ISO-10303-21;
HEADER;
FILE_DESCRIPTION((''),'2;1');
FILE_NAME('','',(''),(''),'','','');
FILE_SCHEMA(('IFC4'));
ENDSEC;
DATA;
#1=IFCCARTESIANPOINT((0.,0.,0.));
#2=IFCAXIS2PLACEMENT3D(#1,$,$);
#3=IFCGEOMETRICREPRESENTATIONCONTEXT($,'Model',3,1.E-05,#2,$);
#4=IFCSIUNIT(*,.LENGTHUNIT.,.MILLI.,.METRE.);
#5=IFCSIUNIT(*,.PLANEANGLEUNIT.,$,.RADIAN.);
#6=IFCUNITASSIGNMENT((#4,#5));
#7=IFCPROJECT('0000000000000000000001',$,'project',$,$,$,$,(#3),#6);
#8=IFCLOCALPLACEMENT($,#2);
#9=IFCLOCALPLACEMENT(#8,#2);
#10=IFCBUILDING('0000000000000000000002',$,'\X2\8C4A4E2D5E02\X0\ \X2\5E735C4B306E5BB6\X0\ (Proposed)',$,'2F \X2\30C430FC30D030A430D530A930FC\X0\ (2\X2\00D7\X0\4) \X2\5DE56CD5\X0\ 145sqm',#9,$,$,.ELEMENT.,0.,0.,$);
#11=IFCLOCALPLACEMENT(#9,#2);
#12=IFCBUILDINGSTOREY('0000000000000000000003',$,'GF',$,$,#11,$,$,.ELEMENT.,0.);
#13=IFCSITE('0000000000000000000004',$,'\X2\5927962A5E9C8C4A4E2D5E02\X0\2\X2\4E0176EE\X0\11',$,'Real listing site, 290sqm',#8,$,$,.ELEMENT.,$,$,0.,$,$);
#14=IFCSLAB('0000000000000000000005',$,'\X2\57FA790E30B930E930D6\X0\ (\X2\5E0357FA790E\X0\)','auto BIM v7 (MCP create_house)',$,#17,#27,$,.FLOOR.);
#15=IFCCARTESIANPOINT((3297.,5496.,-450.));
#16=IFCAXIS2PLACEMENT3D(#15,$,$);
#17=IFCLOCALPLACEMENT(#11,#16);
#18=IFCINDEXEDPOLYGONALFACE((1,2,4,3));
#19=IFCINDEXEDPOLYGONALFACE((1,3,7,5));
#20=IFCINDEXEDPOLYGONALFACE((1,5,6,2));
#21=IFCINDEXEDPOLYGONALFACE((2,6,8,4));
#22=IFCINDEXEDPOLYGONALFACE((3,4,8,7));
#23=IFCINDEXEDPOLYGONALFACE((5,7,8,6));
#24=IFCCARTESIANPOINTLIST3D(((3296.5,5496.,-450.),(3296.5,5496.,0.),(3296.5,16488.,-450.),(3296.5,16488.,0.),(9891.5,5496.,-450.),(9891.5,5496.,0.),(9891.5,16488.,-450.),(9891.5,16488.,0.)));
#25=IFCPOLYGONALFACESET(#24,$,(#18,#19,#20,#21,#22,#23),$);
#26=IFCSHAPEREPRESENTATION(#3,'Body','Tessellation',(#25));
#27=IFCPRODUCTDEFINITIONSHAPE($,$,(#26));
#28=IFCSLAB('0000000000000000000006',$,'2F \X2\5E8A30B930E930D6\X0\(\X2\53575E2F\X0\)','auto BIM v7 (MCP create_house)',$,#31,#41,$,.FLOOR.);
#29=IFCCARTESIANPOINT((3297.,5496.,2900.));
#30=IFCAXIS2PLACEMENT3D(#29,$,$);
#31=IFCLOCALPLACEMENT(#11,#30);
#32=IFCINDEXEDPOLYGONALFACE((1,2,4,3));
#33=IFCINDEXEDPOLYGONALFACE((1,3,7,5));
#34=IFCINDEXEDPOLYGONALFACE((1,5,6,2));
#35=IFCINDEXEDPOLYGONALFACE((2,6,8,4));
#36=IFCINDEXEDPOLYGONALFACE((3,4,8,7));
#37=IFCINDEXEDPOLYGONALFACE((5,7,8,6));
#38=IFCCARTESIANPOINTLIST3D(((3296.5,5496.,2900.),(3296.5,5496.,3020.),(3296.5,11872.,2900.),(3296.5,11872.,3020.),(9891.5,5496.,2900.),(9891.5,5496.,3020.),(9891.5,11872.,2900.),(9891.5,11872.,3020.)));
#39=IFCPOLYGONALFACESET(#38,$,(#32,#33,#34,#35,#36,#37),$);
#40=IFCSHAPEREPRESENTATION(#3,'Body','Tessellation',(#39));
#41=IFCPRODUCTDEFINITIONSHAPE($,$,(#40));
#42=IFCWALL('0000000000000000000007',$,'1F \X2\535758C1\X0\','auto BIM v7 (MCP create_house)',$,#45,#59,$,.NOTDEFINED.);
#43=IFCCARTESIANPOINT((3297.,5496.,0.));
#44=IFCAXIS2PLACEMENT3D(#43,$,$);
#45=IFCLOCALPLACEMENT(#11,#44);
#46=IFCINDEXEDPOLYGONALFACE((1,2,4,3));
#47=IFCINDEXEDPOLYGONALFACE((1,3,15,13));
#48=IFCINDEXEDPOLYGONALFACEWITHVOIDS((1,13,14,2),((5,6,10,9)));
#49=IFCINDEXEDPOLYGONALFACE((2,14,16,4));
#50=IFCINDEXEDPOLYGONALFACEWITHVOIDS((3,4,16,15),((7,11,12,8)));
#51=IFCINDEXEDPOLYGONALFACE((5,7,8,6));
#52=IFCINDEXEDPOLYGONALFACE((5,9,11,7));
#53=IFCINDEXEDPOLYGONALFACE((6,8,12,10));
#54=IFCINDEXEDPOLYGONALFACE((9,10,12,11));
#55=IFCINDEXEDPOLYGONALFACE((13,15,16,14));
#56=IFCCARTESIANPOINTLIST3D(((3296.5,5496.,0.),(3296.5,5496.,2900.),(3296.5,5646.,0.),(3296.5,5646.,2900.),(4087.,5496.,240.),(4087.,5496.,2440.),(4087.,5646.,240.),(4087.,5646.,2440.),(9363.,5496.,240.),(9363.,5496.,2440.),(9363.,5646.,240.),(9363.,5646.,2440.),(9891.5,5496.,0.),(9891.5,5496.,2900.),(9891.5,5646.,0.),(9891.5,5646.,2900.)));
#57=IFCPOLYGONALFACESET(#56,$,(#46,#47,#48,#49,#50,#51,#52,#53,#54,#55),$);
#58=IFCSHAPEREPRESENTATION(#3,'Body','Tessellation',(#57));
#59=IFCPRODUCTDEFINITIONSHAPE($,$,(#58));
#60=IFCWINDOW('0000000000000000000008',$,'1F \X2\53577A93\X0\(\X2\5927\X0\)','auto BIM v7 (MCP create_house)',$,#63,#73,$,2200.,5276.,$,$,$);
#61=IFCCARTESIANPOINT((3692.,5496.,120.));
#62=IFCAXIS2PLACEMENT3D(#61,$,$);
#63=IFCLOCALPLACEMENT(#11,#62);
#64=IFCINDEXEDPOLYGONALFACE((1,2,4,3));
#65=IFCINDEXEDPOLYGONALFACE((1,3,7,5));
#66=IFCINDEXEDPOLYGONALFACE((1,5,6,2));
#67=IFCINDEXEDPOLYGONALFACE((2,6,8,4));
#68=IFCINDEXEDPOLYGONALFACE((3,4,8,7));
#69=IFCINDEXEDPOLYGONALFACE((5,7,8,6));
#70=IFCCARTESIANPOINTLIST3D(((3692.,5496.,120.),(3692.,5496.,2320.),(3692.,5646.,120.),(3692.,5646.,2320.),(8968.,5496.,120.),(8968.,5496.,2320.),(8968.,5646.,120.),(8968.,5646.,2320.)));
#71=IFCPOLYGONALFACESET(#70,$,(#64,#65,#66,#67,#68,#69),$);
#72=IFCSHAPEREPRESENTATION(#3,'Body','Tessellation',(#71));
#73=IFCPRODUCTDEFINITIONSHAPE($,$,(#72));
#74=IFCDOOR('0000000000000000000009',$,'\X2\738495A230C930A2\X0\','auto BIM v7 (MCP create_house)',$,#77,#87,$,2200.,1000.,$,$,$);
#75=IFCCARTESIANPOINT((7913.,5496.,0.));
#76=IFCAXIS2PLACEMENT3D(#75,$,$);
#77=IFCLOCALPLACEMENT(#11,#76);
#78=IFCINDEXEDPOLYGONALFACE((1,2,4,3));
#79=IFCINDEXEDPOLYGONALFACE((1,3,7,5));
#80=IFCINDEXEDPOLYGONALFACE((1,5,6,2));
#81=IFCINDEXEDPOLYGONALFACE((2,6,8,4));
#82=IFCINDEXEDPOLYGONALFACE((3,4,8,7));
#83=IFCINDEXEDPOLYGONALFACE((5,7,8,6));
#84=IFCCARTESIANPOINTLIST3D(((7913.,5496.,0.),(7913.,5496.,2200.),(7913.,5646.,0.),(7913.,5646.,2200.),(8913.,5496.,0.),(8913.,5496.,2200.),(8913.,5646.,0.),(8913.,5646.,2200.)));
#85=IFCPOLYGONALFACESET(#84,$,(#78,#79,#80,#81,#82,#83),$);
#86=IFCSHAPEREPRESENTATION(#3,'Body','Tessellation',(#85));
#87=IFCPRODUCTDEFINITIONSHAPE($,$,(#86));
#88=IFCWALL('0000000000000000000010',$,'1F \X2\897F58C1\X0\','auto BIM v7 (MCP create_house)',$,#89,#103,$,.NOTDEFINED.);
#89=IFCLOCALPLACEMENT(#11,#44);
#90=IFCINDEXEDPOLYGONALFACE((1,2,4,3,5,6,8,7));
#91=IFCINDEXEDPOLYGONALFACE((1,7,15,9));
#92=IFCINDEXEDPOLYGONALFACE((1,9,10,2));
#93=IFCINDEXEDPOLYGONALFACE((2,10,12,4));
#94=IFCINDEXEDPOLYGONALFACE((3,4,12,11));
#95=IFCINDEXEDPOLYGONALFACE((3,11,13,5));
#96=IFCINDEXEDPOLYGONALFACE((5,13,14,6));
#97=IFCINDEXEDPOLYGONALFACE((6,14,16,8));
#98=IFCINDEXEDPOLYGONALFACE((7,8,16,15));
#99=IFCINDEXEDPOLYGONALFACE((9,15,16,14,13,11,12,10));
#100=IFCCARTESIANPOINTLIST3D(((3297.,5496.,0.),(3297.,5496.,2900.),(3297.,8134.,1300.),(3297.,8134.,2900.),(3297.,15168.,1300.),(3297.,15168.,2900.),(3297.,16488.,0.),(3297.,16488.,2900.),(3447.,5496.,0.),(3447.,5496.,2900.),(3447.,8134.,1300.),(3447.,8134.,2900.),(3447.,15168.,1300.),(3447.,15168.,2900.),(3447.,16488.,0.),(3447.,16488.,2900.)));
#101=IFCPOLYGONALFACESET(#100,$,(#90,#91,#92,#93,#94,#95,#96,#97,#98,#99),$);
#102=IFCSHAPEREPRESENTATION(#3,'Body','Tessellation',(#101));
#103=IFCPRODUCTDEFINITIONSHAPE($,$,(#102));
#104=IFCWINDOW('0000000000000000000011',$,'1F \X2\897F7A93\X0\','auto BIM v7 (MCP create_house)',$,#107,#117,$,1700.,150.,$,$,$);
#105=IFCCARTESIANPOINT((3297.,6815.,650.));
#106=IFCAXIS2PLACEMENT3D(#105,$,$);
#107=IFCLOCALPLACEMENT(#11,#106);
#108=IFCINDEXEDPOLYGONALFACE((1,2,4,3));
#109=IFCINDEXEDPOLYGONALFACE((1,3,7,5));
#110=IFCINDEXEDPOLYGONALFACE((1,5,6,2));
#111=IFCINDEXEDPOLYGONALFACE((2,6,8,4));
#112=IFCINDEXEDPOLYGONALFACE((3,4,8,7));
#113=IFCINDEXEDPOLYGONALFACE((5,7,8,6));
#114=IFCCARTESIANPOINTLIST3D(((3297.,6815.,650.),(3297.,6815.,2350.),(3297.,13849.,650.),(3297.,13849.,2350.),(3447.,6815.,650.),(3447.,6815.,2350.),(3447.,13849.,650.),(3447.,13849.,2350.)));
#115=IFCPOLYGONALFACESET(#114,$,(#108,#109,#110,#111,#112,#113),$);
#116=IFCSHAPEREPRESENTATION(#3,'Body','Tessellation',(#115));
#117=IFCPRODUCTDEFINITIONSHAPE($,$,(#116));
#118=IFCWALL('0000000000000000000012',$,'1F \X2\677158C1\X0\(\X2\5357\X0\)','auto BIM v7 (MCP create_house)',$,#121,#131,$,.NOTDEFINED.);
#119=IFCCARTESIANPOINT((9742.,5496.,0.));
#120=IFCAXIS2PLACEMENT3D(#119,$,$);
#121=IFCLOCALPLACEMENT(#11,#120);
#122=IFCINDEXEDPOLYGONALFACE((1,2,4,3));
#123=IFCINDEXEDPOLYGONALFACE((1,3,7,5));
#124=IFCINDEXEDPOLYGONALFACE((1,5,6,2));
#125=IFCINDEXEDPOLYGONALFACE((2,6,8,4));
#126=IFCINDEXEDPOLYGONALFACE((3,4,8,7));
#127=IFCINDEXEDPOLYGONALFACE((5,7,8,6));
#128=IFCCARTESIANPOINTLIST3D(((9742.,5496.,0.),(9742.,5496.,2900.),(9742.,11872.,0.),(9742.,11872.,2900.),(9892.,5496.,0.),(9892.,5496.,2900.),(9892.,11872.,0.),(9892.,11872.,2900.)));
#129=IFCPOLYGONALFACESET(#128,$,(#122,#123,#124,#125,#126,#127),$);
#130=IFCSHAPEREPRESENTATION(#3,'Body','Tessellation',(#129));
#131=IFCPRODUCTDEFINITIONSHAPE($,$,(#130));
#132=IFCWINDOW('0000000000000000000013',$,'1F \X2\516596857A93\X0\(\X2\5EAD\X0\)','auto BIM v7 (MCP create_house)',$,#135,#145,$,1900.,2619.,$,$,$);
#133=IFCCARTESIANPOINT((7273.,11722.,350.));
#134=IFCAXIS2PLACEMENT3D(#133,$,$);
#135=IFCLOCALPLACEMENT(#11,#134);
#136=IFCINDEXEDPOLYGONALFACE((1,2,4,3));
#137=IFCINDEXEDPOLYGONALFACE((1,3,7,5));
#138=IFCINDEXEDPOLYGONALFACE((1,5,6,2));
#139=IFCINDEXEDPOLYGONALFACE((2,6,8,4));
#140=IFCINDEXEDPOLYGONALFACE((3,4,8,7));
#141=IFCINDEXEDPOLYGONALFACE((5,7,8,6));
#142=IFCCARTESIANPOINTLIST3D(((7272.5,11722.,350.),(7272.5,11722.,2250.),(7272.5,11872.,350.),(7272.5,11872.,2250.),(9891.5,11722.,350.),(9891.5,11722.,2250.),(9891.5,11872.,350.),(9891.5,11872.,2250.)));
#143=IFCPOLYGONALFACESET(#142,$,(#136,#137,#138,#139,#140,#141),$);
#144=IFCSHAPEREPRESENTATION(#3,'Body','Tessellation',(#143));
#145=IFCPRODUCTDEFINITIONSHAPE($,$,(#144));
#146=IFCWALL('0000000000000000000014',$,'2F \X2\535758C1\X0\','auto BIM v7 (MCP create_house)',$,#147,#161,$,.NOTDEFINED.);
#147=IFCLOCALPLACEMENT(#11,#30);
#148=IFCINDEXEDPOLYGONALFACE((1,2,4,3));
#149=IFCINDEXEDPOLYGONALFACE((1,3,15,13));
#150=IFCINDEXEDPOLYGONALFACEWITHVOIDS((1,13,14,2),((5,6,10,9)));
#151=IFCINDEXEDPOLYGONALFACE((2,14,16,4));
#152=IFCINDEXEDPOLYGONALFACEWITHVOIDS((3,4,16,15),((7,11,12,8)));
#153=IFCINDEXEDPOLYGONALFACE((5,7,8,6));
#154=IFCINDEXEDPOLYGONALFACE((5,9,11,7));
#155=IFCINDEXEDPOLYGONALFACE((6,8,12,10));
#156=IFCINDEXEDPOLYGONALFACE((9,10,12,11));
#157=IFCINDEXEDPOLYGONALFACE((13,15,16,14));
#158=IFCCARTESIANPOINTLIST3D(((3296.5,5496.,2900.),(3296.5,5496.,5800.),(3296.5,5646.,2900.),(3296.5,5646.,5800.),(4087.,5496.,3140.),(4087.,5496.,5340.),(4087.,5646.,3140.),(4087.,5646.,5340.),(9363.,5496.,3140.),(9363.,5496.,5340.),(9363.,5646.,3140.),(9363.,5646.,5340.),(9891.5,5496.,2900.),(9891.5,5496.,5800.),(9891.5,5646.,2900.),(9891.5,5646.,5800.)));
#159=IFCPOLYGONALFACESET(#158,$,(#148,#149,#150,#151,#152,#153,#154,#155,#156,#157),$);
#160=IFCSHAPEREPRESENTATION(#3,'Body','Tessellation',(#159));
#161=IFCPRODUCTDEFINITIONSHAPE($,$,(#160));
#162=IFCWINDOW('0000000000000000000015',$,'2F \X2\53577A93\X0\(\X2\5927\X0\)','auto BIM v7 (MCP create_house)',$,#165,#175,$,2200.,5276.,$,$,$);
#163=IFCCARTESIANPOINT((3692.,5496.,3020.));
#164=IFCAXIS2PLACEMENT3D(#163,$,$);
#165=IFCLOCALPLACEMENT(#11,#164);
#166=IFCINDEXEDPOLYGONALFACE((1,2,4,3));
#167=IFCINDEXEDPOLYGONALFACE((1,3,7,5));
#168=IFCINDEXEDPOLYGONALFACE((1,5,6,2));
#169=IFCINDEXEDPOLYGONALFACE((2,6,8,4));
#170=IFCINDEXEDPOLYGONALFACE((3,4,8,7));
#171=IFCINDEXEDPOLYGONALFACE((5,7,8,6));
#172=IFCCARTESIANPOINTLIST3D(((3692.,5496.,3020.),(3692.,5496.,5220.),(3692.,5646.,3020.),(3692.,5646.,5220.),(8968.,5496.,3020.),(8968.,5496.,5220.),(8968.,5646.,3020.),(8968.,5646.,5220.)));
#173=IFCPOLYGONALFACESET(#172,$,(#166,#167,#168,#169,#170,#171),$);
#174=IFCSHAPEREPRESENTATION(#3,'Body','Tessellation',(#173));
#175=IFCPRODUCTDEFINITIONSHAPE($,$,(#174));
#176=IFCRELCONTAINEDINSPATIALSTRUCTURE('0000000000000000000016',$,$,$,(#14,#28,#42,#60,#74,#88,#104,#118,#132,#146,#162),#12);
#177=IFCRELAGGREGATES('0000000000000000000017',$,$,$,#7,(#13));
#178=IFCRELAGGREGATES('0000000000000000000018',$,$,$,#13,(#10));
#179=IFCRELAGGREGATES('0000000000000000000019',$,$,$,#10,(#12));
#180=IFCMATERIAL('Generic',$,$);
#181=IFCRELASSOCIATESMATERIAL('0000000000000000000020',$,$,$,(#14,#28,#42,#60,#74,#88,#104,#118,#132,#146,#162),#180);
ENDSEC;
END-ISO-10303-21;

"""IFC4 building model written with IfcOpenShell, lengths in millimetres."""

from ifc_helpers import new_model, si_unit, frame, frame_2d, origin, place, context, project, spatial, rectangle, extrude, material, element, fill, save


model = new_model("IFC4")

# Units and contexts
model_context = context("Model", 3, precision=1e-05, world=origin())
ifc_project = project(units=[si_unit("LENGTHUNIT", "METRE", prefix="MILLI"), si_unit("PLANEANGLEUNIT", "RADIAN")], contexts=[model_context])

# Site, building, storey
site_placement = place(None, origin())
site = spatial("IfcSite", under=ifc_project, at=site_placement, Name="大阪府豊中市2丁目11", ObjectType="Real listing site, 290sqm", CompositionType="ELEMENT", RefElevation=0.0)
building_placement = place(site_placement, origin())
building = spatial("IfcBuilding", under=site, at=building_placement, Name="豊中市 平屋の家 (Proposed)", ObjectType="2F ツーバイフォー (2×4) 工法 145sqm", CompositionType="ELEMENT", ElevationOfRefHeight=0.0, ElevationOfTerrain=0.0)
storey_placement = place(building_placement, origin())
storey = spatial("IfcBuildingStorey", under=building, at=storey_placement, Name="GF", CompositionType="ELEMENT", Elevation=0.0)

# Slabs
ifc_material = material(Name="Generic")
slab_1_placement = place(storey_placement, frame((3297.0, 5496.0, -450.0)))
element("IfcSlab", 1, at=slab_1_placement, inside=storey, material=ifc_material, Name="基礎スラブ (布基礎)", Description="auto BIM v7 (MCP create_house)", PredefinedType="FLOOR", context=model_context, shape_type="SweptSolid", body=[
    extrude(rectangle(XDim=6595.0, YDim=10992.0, at=frame_2d((3297.0, 5496.0))), frame((3297.0, 5496.0, -450.0)), (0.0, 0.0, 1.0), 450.0),
])
slab_2_placement = place(storey_placement, frame((3297.0, 5496.0, 2900.0)))
element("IfcSlab", 2, at=slab_2_placement, inside=storey, material=ifc_material, Name="2F 床スラブ(南帯)", Description="auto BIM v7 (MCP create_house)", PredefinedType="FLOOR", context=model_context, shape_type="SweptSolid", body=[
    extrude(rectangle(XDim=6595.0, YDim=6376.0, at=frame_2d((3297.0, 3188.0))), frame((3297.0, 5496.0, 2900.0)), (0.0, 0.0, 1.0), 120.0),
])

# Wall, openings, window, door
wall_1_placement = place(storey_placement, frame((3297.0, 5496.0, 0.0)))
wall_1 = element("IfcWall", 3, at=wall_1_placement, inside=storey, material=ifc_material, Name="1F 南壁", Description="auto BIM v7 (MCP create_house)", PredefinedType="NOTDEFINED", context=model_context, shape_type="SweptSolid", body=[
    extrude(rectangle(XDim=6595.0, YDim=150.0, at=frame_2d((3297.0, 75.0))), frame((3297.0, 5496.0, 0.0)), (0.0, 0.0, 1.0), 2900.0),
])
opening_1_placement = place(storey_placement, frame((3692.0, 5496.0, 120.0)))
opening_1 = element("IfcOpeningElement", 4, at=opening_1_placement, cuts=wall_1, PredefinedType="NOTDEFINED", context=model_context, shape_type="SweptSolid", body=[
    extrude(rectangle(XDim=5276.0, YDim=150.0, at=frame_2d((2638.0, 75.0))), frame((3692.0, 5496.0, 120.0)), (0.0, 0.0, 1.0), 2200.0),
])
opening_2_placement = place(storey_placement, frame((7913.0, 5496.0, 0.0)))
opening_2 = element("IfcOpeningElement", 5, at=opening_2_placement, cuts=wall_1, PredefinedType="NOTDEFINED", context=model_context, shape_type="SweptSolid", body=[
    extrude(rectangle(XDim=1000.0, YDim=150.0, at=frame_2d((500.0, 75.0))), frame((7913.0, 5496.0, 0.0)), (0.0, 0.0, 1.0), 2200.0),
])
window_1_placement = place(storey_placement, frame((3692.0, 5496.0, 120.0)))
window_1 = element("IfcWindow", 6, at=window_1_placement, inside=storey, material=ifc_material, Name="1F 南窓(大)", Description="auto BIM v7 (MCP create_house)", OverallHeight=2200.0, OverallWidth=5276.0, context=model_context, shape_type="SweptSolid", body=[
    extrude(rectangle(XDim=5276.0, YDim=150.0, at=frame_2d((2638.0, 75.0))), frame((3692.0, 5496.0, 120.0)), (0.0, 0.0, 1.0), 2200.0),
])
fill(opening_1, window_1)
door_placement = place(storey_placement, frame((7913.0, 5496.0, 0.0)))
door = element("IfcDoor", 7, at=door_placement, inside=storey, material=ifc_material, Name="玄関ドア", Description="auto BIM v7 (MCP create_house)", OverallHeight=2200.0, OverallWidth=1000.0, context=model_context, shape_type="SweptSolid", body=[
    extrude(rectangle(XDim=1000.0, YDim=150.0, at=frame_2d((500.0, 75.0))), frame((7913.0, 5496.0, 0.0)), (0.0, 0.0, 1.0), 2200.0),
])
fill(opening_2, door)

# Walls, openings, windows
wall_2_placement = place(storey_placement, frame((3297.0, 5496.0, 0.0)))
wall_2 = element("IfcWall", 8, at=wall_2_placement, inside=storey, material=ifc_material, Name="1F 西壁", Description="auto BIM v7 (MCP create_house)", PredefinedType="NOTDEFINED", context=model_context, shape_type="SweptSolid", body=[
    extrude(rectangle(XDim=150.0, YDim=10992.0, at=frame_2d((75.0, 5496.0))), frame((3297.0, 5496.0, 0.0)), (0.0, 0.0, 1.0), 2900.0),
])
opening_3_placement = place(storey_placement, frame((3297.0, 6815.0, 650.0)))
opening_3 = element("IfcOpeningElement", 9, at=opening_3_placement, cuts=wall_2, PredefinedType="NOTDEFINED", context=model_context, shape_type="SweptSolid", body=[
    extrude(rectangle(XDim=150.0, YDim=7034.0, at=frame_2d((75.0, 3517.0))), frame((3297.0, 6815.0, 650.0)), (0.0, 0.0, 1.0), 1700.0),
])
window_2_placement = place(storey_placement, frame((3297.0, 6815.0, 650.0)))
window_2 = element("IfcWindow", 10, at=window_2_placement, inside=storey, material=ifc_material, Name="1F 西窓", Description="auto BIM v7 (MCP create_house)", OverallHeight=1700.0, OverallWidth=150.0, context=model_context, shape_type="SweptSolid", body=[
    extrude(rectangle(XDim=150.0, YDim=7034.0, at=frame_2d((75.0, 3517.0))), frame((3297.0, 6815.0, 650.0)), (0.0, 0.0, 1.0), 1700.0),
])
fill(opening_3, window_2)
wall_3_placement = place(storey_placement, frame((9742.0, 5496.0, 0.0)))
wall_3 = element("IfcWall", 11, at=wall_3_placement, inside=storey, material=ifc_material, Name="1F 東壁(南)", Description="auto BIM v7 (MCP create_house)", PredefinedType="NOTDEFINED", context=model_context, shape_type="SweptSolid", body=[
    extrude(rectangle(XDim=150.0, YDim=6376.0, at=frame_2d((75.0, 3188.0))), frame((9742.0, 5496.0, 0.0)), (0.0, 0.0, 1.0), 2900.0),
])
opening_4_placement = place(storey_placement, frame((7273.0, 11722.0, 350.0)))
opening_4 = element("IfcOpeningElement", 12, at=opening_4_placement, cuts=wall_3, PredefinedType="NOTDEFINED", context=model_context, shape_type="SweptSolid", body=[
    extrude(rectangle(XDim=2619.0, YDim=150.0, at=frame_2d((1309.0, 75.0))), frame((7273.0, 11722.0, 350.0)), (0.0, 0.0, 1.0), 1900.0),
])
window_3_placement = place(storey_placement, frame((7273.0, 11722.0, 350.0)))
window_3 = element("IfcWindow", 13, at=window_3_placement, inside=storey, material=ifc_material, Name="1F 入隅窓(庭)", Description="auto BIM v7 (MCP create_house)", OverallHeight=1900.0, OverallWidth=2619.0, context=model_context, shape_type="SweptSolid", body=[
    extrude(rectangle(XDim=2619.0, YDim=150.0, at=frame_2d((1309.0, 75.0))), frame((7273.0, 11722.0, 350.0)), (0.0, 0.0, 1.0), 1900.0),
])
fill(opening_4, window_3)

# Wall, opening, window
wall_4_placement = place(storey_placement, frame((3297.0, 5496.0, 2900.0)))
wall_4 = element("IfcWall", 14, at=wall_4_placement, inside=storey, material=ifc_material, Name="2F 南壁", Description="auto BIM v7 (MCP create_house)", PredefinedType="NOTDEFINED", context=model_context, shape_type="SweptSolid", body=[
    extrude(rectangle(XDim=6595.0, YDim=150.0, at=frame_2d((3297.0, 75.0))), frame((3297.0, 5496.0, 2900.0)), (0.0, 0.0, 1.0), 2900.0),
])
opening_5_placement = place(storey_placement, frame((3692.0, 5496.0, 3020.0)))
opening_5 = element("IfcOpeningElement", 15, at=opening_5_placement, cuts=wall_4, PredefinedType="NOTDEFINED", context=model_context, shape_type="SweptSolid", body=[
    extrude(rectangle(XDim=5276.0, YDim=150.0, at=frame_2d((2638.0, 75.0))), frame((3692.0, 5496.0, 3020.0)), (0.0, 0.0, 1.0), 2200.0),
])
window_4_placement = place(storey_placement, frame((3692.0, 5496.0, 3020.0)))
window_4 = element("IfcWindow", 16, at=window_4_placement, inside=storey, material=ifc_material, Name="2F 南窓(大)", Description="auto BIM v7 (MCP create_house)", OverallHeight=2200.0, OverallWidth=5276.0, context=model_context, shape_type="SweptSolid", body=[
    extrude(rectangle(XDim=5276.0, YDim=150.0, at=frame_2d((2638.0, 75.0))), frame((3692.0, 5496.0, 3020.0)), (0.0, 0.0, 1.0), 2200.0),
])
fill(opening_5, window_4)

save(model, "model.ifc")
